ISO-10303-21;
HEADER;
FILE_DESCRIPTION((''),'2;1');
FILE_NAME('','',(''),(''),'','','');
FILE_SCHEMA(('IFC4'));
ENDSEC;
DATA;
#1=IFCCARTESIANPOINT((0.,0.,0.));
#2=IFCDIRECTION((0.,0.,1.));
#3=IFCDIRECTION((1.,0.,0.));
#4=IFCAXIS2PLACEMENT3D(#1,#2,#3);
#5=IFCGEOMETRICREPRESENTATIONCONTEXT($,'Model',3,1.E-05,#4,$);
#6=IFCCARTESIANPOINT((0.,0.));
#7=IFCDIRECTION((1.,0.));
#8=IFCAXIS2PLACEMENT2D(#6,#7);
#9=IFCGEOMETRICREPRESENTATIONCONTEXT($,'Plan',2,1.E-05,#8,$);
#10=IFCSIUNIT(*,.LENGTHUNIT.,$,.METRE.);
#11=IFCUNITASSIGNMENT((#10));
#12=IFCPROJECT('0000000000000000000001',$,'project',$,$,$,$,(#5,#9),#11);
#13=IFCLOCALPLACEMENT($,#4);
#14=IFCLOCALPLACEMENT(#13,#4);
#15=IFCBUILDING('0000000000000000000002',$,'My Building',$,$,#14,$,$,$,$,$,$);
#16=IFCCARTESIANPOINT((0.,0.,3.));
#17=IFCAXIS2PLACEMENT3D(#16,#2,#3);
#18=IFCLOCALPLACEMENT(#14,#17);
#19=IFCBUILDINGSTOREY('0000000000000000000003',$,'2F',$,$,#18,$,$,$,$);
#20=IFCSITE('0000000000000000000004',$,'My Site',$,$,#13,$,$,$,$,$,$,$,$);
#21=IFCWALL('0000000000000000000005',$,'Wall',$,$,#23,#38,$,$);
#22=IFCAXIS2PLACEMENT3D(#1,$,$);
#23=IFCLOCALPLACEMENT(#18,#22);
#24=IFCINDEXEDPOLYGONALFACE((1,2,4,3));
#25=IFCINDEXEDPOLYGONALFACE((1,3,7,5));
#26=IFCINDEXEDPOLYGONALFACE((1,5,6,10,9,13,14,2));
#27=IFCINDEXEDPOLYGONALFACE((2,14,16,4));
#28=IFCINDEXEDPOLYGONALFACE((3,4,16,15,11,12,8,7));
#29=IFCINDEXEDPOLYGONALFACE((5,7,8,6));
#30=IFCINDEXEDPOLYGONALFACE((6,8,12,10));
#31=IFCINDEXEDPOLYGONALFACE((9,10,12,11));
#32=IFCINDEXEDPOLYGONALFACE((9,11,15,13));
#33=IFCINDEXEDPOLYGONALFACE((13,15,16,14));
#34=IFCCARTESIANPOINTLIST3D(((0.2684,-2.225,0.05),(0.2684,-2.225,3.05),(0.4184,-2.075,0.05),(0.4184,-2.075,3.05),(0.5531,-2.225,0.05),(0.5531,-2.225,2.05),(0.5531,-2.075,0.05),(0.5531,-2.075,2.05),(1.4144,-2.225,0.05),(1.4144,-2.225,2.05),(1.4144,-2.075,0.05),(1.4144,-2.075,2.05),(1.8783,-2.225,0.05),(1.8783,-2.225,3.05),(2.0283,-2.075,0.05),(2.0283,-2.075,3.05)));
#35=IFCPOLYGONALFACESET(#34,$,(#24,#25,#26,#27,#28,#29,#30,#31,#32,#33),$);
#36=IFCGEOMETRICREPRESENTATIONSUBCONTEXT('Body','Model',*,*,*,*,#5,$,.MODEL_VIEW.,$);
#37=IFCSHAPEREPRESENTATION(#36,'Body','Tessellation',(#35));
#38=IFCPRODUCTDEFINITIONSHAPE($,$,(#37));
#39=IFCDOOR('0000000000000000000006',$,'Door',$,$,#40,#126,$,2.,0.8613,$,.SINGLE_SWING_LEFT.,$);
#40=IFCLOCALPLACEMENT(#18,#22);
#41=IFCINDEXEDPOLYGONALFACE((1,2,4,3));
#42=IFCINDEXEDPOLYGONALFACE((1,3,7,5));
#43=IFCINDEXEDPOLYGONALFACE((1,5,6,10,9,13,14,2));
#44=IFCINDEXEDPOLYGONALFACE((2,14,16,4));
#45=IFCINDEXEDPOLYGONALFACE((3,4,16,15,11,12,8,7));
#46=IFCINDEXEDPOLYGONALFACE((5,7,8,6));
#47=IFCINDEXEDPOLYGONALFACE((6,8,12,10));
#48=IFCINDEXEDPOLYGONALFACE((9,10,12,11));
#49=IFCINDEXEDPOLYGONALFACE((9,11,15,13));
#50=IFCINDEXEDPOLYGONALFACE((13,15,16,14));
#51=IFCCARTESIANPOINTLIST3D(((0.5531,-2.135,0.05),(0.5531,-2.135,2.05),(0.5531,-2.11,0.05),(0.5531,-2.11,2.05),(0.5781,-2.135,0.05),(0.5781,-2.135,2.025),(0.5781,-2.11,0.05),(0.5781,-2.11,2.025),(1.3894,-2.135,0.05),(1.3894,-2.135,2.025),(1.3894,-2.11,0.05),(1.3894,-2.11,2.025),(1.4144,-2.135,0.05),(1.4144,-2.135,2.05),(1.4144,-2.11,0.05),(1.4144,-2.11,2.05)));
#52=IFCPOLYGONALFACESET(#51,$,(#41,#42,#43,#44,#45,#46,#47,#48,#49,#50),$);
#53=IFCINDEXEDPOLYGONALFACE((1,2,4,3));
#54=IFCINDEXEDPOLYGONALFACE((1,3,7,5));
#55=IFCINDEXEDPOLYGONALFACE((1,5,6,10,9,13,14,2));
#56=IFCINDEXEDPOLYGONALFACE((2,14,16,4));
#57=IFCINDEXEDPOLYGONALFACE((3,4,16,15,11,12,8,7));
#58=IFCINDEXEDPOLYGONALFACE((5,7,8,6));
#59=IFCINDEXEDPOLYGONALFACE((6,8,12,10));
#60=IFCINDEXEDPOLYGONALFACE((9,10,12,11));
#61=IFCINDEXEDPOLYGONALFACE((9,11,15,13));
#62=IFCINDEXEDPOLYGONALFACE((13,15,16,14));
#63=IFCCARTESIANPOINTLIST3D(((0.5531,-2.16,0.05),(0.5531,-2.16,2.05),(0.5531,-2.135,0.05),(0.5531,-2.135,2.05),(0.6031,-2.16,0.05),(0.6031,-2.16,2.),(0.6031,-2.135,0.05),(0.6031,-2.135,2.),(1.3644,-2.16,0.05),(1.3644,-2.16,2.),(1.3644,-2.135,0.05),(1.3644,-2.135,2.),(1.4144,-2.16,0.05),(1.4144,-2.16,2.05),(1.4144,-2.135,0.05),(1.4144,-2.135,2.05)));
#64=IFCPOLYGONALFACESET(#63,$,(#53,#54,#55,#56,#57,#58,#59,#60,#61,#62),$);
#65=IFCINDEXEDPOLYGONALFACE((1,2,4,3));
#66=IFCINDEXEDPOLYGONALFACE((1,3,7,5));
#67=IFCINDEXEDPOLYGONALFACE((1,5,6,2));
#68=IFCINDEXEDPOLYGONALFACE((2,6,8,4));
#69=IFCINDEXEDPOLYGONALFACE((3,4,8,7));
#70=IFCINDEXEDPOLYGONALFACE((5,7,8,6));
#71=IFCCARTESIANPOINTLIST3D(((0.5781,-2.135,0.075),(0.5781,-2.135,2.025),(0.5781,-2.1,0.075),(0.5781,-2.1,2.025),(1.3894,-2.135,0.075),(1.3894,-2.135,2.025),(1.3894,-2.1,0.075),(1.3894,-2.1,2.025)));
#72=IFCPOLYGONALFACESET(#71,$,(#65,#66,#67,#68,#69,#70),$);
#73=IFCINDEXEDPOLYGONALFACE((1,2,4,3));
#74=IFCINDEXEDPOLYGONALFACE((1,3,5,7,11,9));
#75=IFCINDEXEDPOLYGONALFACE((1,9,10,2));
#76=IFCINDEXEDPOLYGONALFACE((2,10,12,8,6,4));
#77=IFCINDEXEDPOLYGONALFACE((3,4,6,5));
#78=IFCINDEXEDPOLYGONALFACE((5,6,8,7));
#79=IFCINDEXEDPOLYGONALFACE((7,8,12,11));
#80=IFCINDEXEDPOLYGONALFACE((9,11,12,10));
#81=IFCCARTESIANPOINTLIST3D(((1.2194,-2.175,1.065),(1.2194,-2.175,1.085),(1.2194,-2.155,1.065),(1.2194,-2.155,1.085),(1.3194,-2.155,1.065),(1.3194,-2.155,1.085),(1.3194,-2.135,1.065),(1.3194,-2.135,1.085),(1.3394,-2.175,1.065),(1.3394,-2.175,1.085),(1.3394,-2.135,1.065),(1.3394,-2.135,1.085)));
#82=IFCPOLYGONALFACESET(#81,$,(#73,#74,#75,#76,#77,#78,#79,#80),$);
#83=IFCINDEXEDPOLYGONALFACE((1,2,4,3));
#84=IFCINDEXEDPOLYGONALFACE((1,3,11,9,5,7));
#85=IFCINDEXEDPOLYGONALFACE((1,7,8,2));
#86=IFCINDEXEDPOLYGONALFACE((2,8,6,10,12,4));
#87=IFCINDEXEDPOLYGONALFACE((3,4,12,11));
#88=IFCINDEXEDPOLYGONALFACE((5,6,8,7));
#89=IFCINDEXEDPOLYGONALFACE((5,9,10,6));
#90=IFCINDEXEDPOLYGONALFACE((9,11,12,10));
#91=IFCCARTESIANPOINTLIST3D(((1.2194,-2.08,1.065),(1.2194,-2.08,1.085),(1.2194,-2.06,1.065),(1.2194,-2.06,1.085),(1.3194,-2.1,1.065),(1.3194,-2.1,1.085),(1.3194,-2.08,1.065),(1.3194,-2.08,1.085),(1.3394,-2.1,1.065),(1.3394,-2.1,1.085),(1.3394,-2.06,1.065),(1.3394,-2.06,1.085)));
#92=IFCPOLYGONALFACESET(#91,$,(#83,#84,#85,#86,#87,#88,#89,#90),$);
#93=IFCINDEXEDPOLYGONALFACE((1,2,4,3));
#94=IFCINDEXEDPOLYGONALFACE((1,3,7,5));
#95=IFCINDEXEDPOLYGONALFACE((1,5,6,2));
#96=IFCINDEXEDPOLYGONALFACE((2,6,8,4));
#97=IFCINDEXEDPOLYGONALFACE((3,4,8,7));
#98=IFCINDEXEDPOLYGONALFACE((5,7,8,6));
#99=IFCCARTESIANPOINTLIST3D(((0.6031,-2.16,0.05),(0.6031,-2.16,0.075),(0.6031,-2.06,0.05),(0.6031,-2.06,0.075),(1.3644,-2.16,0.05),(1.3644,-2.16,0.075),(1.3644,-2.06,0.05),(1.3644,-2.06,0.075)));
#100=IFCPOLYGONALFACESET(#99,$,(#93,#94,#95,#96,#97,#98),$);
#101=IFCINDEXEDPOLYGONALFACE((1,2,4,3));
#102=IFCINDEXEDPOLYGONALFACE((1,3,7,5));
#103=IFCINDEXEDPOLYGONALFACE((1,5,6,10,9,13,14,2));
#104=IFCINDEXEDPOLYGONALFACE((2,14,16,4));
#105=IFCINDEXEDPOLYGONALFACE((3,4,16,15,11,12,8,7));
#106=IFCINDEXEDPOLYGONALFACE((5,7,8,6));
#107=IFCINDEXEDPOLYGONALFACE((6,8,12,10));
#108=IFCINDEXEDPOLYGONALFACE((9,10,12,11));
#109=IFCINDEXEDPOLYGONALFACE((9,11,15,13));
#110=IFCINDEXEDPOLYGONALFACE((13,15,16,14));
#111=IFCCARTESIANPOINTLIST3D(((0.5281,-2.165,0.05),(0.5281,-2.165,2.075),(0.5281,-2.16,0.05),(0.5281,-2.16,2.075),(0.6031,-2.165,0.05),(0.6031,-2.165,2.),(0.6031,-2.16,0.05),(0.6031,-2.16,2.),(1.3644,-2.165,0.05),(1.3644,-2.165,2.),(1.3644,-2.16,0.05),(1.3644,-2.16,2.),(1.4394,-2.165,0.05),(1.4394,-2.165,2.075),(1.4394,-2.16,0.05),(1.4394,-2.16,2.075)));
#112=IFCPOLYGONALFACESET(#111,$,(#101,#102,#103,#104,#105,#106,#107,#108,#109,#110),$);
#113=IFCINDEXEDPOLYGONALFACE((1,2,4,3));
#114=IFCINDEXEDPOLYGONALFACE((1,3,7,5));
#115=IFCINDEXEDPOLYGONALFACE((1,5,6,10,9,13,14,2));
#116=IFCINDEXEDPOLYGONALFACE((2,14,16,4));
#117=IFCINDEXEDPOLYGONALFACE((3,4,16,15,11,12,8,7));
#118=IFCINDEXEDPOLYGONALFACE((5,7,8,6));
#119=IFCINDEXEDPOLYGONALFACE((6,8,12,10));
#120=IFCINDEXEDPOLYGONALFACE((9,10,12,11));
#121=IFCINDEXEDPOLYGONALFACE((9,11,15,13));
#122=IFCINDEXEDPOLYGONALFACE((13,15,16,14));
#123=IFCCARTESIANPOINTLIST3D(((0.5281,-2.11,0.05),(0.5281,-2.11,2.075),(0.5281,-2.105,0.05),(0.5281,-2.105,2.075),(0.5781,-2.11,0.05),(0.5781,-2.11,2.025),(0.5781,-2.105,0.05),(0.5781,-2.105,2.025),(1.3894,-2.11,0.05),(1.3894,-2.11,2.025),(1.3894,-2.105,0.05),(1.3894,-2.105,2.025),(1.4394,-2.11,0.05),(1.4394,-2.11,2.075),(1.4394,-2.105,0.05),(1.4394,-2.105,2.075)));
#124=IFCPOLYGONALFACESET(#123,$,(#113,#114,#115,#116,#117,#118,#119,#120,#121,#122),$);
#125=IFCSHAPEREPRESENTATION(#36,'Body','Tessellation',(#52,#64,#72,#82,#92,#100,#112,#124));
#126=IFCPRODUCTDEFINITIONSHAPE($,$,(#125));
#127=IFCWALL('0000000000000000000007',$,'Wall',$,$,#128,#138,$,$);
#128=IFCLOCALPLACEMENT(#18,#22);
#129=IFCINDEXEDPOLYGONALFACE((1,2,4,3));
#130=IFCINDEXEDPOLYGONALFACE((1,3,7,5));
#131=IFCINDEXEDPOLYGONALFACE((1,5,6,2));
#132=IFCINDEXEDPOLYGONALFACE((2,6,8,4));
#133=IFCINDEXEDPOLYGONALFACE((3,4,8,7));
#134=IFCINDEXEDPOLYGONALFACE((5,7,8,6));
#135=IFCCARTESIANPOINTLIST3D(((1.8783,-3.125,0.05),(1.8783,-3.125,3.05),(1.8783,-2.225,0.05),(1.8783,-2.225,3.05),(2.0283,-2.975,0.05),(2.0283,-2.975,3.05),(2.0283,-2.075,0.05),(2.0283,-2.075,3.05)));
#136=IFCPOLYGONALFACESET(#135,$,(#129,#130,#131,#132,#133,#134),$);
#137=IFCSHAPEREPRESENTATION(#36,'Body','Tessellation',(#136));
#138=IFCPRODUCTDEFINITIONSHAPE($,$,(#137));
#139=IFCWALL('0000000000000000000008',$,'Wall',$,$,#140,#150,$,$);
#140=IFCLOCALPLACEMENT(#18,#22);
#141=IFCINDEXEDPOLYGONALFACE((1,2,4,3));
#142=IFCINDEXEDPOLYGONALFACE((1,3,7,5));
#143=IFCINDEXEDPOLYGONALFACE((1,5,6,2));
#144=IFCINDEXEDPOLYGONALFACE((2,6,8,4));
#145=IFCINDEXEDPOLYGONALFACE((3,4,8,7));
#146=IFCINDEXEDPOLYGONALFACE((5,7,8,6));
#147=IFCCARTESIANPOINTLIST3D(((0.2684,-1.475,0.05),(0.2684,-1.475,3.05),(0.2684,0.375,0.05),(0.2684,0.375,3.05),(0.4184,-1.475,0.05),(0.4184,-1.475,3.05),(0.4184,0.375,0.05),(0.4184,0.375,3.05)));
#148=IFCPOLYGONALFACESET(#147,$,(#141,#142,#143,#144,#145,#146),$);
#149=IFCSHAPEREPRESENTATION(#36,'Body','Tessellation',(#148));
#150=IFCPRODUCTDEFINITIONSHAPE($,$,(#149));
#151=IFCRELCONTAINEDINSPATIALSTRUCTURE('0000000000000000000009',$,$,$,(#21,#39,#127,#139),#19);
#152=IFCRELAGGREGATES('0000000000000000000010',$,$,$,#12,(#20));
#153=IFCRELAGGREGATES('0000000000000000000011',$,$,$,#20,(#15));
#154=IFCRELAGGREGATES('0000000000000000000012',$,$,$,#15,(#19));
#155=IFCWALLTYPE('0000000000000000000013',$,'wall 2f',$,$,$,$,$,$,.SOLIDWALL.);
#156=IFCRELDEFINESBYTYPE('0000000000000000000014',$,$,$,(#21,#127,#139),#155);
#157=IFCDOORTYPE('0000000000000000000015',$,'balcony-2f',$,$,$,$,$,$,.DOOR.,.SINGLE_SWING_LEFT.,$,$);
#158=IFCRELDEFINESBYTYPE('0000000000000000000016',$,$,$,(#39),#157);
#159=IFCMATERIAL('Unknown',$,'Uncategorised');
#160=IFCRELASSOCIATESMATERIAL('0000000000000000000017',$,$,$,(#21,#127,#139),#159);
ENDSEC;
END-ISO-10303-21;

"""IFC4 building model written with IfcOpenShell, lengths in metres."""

from ifc_helpers import new_model, entity, si_unit, frame, origin_with_axes, origin_2d_with_axis, place, context, subcontext, project, spatial, line, indexed_curve, outline, extrude, shape, source, transform, mapped, material, type_object, type_shapes, element, fill, save


model = new_model("IFC4")

# Units and contexts
model_context = context("Model", 3, precision=1e-05, world=origin_with_axes())
plan_context = context("Plan", 2, precision=1e-05, world=origin_2d_with_axis())
body_context_1 = subcontext(model_context, "Body", "Model", "MODEL_VIEW")
body_context_2 = subcontext(plan_context, "Body", "Plan", "PLAN_VIEW")
ifc_project = project(units=[si_unit("LENGTHUNIT", "METRE")], contexts=[model_context, plan_context])

# Site, building, storey
site_placement = place(None, origin_with_axes())
site = spatial("IfcSite", under=ifc_project, at=site_placement, Name="My Site")
building_placement = place(site_placement, origin_with_axes())
building = spatial("IfcBuilding", under=site, at=building_placement, Name="My Building")
storey_placement = place(building_placement, frame((0.0, 0.0, 3.0), z_axis=(0.0, 0.0, 1.0), x_axis=(1.0, 0.0, 0.0)))
storey = spatial("IfcBuildingStorey", under=building, at=storey_placement, Name="2F")

# Shared definitions
ifc_material = material(Name="Unknown", Category="Uncategorised")

# Shared definitions
wall_type_1 = type_object("IfcWallType", Name="wall 2f", PredefinedType="SOLIDWALL")

# Wall, opening, door
wall_1_placement = place(storey_placement, frame((0.2684, -2.225, 0.05), z_axis=(0.0, 0.0, 1.0), x_axis=(1.0, 0.0, 0.0)))
wall_1 = element("IfcWall", 1, at=wall_1_placement, inside=storey, type_object=wall_type_1, material=ifc_material, Name="Wall", context=body_context_1, shape_type="SweptSolid", body=[
    extrude(outline(indexed_curve([(0.0, 0.0), (0.15, 0.15), (1.76, 0.15), (1.61, 0.0)], segments=[line(1, 2, 3, 4, 1)])), origin_with_axes(), (0.0, 0.0, 1.0), 3.0),
])
shared_shape_1 = source(origin_with_axes(), body_context_1, "Body", "SweptSolid", [
    extrude(outline(indexed_curve([(0.0, 0.0), (0.8613, 0.0), (0.8613, 2.0), (0.0, 2.0)], segments=[line(1, 2, 3, 4, 1)])), frame((0.0, -0.6, 0.0), z_axis=(0.0, -1.0, 0.0), x_axis=(1.0, 0.0, 0.0)), (0.0, 0.0, -1.0), 1.2),
])
opening_1_placement = place(wall_1_placement, frame((0.2847, 0.065, 0.0), z_axis=(0.0, 0.0, 1.0), x_axis=(1.0, 0.0, 0.0)))
opening_1 = element("IfcOpeningElement", 2, at=opening_1_placement, cuts=wall_1, PredefinedType="OPENING", context=body_context_1, shape_type="MappedRepresentation", body=[
    mapped(shared_shape_1, transform((0.0, 0.0, 0.0), x_axis=(1.0, 0.0, 0.0), y_axis=(0.0, 1.0, 0.0), z_axis=(0.0, 0.0, 1.0), scale=1.0)),
])
door_type_1 = type_object("IfcDoorType", Name="balcony-2f", OperationType="SINGLE_SWING_LEFT", PredefinedType="DOOR")
shared_shape_2 = source(origin_with_axes(), body_context_1, "Body", "SweptSolid", [
    extrude(outline(indexed_curve([(0.0, 0.0), (0.0, 2.0), (0.8613, 2.0), (0.8613, 0.0), (0.8363, 0.0), (0.8363, 1.975), (0.025, 1.975), (0.025, 0.0)], segments=[line(1, 2, 3, 4, 5, 6, 7, 8, 1)])), frame((0.0, 0.025, 0.0), z_axis=(0.0, -1.0, 0.0), x_axis=(1.0, 0.0, 0.0)), (0.0, 0.0, -1.0), 0.025),
    extrude(outline(indexed_curve([(0.0, 0.0), (0.0, 2.0), (0.8613, 2.0), (0.8613, 0.0), (0.8113, 0.0), (0.8113, 1.95), (0.05, 1.95), (0.05, 0.0)], segments=[line(1, 2, 3, 4, 5, 6, 7, 8, 1)])), frame((0.0, 0.0, 0.0), z_axis=(0.0, -1.0, 0.0), x_axis=(1.0, 0.0, 0.0)), (0.0, 0.0, -1.0), 0.025),
    extrude(outline(indexed_curve([(0.0, 0.0), (0.8113, 0.0), (0.8113, 0.035), (0.0, 0.035)], segments=[line(1, 2, 3, 4, 1)])), frame((0.025, 0.025, 0.025), z_axis=(0.0, 0.0, 1.0), x_axis=(1.0, 0.0, 0.0)), (0.0, 0.0, 1.0), 1.95),
    extrude(outline(indexed_curve([(0.0, 0.0), (0.0, -0.04), (-0.12, -0.04), (-0.12, -0.02), (-0.02, -0.02), (-0.02, 0.0)], segments=[line(1, 2, 3, 4, 5, 6, 1)])), frame((0.7863, 0.025, 1.015), z_axis=(0.0, 0.0, 1.0), x_axis=(1.0, 0.0, 0.0)), (0.0, 0.0, 1.0), 0.02),
    extrude(outline(indexed_curve([(0.0, 0.0), (0.0, 0.04), (-0.12, 0.04), (-0.12, 0.02), (-0.02, 0.02), (-0.02, 0.0)], segments=[line(1, 2, 3, 4, 5, 6, 1)])), frame((0.7863, 0.06, 1.015), z_axis=(0.0, 0.0, 1.0), x_axis=(1.0, 0.0, 0.0)), (0.0, 0.0, 1.0), 0.02),
    extrude(outline(indexed_curve([(0.0, 0.0), (0.7613, 0.0), (0.7613, 0.1), (0.0, 0.1)], segments=[line(1, 2, 3, 4, 1)])), frame((0.05, 0.0, 0.0), z_axis=(0.0, 0.0, 1.0), x_axis=(1.0, 0.0, 0.0)), (0.0, 0.0, 1.0), 0.025),
    extrude(outline(indexed_curve([(0.0, 0.0), (0.0, 2.025), (0.9113, 2.025), (0.9113, 0.0), (0.8363, 0.0), (0.8363, 1.95), (0.075, 1.95), (0.075, 0.0)], segments=[line(1, 2, 3, 4, 5, 6, 7, 8, 1)])), frame((-0.025, -0.005, 0.0), z_axis=(0.0, -1.0, 0.0), x_axis=(1.0, 0.0, 0.0)), (0.0, 0.0, -1.0), 0.005),
    extrude(outline(indexed_curve([(0.0, 0.0), (0.0, 2.025), (0.9113, 2.025), (0.9113, 0.0), (0.8613, 0.0), (0.8613, 1.975), (0.05, 1.975), (0.05, 0.0)], segments=[line(1, 2, 3, 4, 5, 6, 7, 8, 1)])), frame((-0.025, 0.05, 0.0), z_axis=(0.0, -1.0, 0.0), x_axis=(1.0, 0.0, 0.0)), (0.0, 0.0, -1.0), 0.005),
])
shared_shape_3 = source(origin_with_axes(), body_context_2, "Body", "Curve2D", [
    entity("IfcIndexedPolyCurve", entity("IfcCartesianPointList2D", [[0.0, 0.0], [0.0, 0.05], [0.025, 0.05], [0.025, 0.025], [0.05, 0.025], [0.05, 0.0]]), [entity("IfcLineIndex", [1, 2, 3, 4, 5, 6, 1])]),
    entity("IfcIndexedPolyCurve", entity("IfcCartesianPointList2D", [[0.8613, 0.0], [0.8613, 0.05], [0.8363, 0.05], [0.8363, 0.025], [0.8113, 0.025], [0.8113, 0.0]]), [entity("IfcLineIndex", [1, 2, 3, 4, 5, 6, 1])]),
    entity("IfcTrimmedCurve", entity("IfcEllipse", entity("IfcAxis2Placement2D", entity("IfcCartesianPoint", [0.06, 0.05]), entity("IfcDirection", [1.0, 0.0])), 0.7763, 0.8113), [entity("IfcCartesianPoint", [0.8363, 0.05])], [entity("IfcCartesianPoint", [0.06, 0.8613])], True, "CARTESIAN"),
    entity("IfcIndexedPolyCurve", entity("IfcCartesianPointList2D", [[0.025, 0.05], [0.06, 0.05], [0.06, 0.8613], [0.025, 0.8613]]), [entity("IfcLineIndex", [1, 2, 3, 4, 1])]),
])
type_shapes(door_type_1, [shared_shape_2, shared_shape_3])
door_1_placement = place(opening_1_placement, frame((0.0, 0.0, 0.0), z_axis=(0.0, 0.0, 1.0), x_axis=(1.0, 0.0, 0.0)))
door_1 = element("IfcDoor", 3, at=door_1_placement, inside=storey, type_object=door_type_1, Name="Door", OperationType="SINGLE_SWING_LEFT", OverallHeight=2.0, OverallWidth=0.8613, shapes=[
    shape(body_context_1, "Body", "MappedRepresentation", [mapped(shared_shape_2, transform((0.0, 0.0, 0.0), x_axis=(1.0, 0.0, 0.0), y_axis=(0.0, 1.0, 0.0), z_axis=(0.0, 0.0, 1.0), scale=1.0))]),
    shape(body_context_2, "Body", "MappedRepresentation", [mapped(shared_shape_3, transform((0.0, 0.0, 0.0), x_axis=(1.0, 0.0, 0.0), y_axis=(0.0, 1.0, 0.0), z_axis=(0.0, 0.0, 1.0), scale=1.0))]),
])
fill(opening_1, door_1)

# Wall
wall_2_placement = place(storey_placement, frame((1.8783, -2.225, 0.05), z_axis=(0.0, 0.0, 1.0), x_axis=(0.0, -1.0, 0.0)))
element("IfcWall", 4, at=wall_2_placement, inside=storey, type_object=wall_type_1, material=ifc_material, Name="Wall", context=body_context_1, shape_type="SweptSolid", body=[
    extrude(outline(indexed_curve([(0.0, 0.0), (-0.15, 0.15), (0.75, 0.15), (0.9, 0.0)], segments=[line(1, 2, 3, 4, 1)])), origin_with_axes(), (0.0, 0.0, 1.0), 3.0),
])

# Wall
wall_3_placement = place(storey_placement, frame((0.2684, 0.375, 0.05), z_axis=(0.0, 0.0, 1.0), x_axis=(0.0, -1.0, 0.0)))
element("IfcWall", 5, at=wall_3_placement, inside=storey, type_object=wall_type_1, material=ifc_material, Name="Wall", context=body_context_1, shape_type="SweptSolid", body=[
    extrude(outline(indexed_curve([(0.0, 0.0), (0.0, 0.15), (1.85, 0.15), (1.85, 0.0)], segments=[line(1, 2, 3, 4, 1)])), origin_with_axes(), (0.0, 0.0, 1.0), 3.0),
])

save(model, "model.ifc")
